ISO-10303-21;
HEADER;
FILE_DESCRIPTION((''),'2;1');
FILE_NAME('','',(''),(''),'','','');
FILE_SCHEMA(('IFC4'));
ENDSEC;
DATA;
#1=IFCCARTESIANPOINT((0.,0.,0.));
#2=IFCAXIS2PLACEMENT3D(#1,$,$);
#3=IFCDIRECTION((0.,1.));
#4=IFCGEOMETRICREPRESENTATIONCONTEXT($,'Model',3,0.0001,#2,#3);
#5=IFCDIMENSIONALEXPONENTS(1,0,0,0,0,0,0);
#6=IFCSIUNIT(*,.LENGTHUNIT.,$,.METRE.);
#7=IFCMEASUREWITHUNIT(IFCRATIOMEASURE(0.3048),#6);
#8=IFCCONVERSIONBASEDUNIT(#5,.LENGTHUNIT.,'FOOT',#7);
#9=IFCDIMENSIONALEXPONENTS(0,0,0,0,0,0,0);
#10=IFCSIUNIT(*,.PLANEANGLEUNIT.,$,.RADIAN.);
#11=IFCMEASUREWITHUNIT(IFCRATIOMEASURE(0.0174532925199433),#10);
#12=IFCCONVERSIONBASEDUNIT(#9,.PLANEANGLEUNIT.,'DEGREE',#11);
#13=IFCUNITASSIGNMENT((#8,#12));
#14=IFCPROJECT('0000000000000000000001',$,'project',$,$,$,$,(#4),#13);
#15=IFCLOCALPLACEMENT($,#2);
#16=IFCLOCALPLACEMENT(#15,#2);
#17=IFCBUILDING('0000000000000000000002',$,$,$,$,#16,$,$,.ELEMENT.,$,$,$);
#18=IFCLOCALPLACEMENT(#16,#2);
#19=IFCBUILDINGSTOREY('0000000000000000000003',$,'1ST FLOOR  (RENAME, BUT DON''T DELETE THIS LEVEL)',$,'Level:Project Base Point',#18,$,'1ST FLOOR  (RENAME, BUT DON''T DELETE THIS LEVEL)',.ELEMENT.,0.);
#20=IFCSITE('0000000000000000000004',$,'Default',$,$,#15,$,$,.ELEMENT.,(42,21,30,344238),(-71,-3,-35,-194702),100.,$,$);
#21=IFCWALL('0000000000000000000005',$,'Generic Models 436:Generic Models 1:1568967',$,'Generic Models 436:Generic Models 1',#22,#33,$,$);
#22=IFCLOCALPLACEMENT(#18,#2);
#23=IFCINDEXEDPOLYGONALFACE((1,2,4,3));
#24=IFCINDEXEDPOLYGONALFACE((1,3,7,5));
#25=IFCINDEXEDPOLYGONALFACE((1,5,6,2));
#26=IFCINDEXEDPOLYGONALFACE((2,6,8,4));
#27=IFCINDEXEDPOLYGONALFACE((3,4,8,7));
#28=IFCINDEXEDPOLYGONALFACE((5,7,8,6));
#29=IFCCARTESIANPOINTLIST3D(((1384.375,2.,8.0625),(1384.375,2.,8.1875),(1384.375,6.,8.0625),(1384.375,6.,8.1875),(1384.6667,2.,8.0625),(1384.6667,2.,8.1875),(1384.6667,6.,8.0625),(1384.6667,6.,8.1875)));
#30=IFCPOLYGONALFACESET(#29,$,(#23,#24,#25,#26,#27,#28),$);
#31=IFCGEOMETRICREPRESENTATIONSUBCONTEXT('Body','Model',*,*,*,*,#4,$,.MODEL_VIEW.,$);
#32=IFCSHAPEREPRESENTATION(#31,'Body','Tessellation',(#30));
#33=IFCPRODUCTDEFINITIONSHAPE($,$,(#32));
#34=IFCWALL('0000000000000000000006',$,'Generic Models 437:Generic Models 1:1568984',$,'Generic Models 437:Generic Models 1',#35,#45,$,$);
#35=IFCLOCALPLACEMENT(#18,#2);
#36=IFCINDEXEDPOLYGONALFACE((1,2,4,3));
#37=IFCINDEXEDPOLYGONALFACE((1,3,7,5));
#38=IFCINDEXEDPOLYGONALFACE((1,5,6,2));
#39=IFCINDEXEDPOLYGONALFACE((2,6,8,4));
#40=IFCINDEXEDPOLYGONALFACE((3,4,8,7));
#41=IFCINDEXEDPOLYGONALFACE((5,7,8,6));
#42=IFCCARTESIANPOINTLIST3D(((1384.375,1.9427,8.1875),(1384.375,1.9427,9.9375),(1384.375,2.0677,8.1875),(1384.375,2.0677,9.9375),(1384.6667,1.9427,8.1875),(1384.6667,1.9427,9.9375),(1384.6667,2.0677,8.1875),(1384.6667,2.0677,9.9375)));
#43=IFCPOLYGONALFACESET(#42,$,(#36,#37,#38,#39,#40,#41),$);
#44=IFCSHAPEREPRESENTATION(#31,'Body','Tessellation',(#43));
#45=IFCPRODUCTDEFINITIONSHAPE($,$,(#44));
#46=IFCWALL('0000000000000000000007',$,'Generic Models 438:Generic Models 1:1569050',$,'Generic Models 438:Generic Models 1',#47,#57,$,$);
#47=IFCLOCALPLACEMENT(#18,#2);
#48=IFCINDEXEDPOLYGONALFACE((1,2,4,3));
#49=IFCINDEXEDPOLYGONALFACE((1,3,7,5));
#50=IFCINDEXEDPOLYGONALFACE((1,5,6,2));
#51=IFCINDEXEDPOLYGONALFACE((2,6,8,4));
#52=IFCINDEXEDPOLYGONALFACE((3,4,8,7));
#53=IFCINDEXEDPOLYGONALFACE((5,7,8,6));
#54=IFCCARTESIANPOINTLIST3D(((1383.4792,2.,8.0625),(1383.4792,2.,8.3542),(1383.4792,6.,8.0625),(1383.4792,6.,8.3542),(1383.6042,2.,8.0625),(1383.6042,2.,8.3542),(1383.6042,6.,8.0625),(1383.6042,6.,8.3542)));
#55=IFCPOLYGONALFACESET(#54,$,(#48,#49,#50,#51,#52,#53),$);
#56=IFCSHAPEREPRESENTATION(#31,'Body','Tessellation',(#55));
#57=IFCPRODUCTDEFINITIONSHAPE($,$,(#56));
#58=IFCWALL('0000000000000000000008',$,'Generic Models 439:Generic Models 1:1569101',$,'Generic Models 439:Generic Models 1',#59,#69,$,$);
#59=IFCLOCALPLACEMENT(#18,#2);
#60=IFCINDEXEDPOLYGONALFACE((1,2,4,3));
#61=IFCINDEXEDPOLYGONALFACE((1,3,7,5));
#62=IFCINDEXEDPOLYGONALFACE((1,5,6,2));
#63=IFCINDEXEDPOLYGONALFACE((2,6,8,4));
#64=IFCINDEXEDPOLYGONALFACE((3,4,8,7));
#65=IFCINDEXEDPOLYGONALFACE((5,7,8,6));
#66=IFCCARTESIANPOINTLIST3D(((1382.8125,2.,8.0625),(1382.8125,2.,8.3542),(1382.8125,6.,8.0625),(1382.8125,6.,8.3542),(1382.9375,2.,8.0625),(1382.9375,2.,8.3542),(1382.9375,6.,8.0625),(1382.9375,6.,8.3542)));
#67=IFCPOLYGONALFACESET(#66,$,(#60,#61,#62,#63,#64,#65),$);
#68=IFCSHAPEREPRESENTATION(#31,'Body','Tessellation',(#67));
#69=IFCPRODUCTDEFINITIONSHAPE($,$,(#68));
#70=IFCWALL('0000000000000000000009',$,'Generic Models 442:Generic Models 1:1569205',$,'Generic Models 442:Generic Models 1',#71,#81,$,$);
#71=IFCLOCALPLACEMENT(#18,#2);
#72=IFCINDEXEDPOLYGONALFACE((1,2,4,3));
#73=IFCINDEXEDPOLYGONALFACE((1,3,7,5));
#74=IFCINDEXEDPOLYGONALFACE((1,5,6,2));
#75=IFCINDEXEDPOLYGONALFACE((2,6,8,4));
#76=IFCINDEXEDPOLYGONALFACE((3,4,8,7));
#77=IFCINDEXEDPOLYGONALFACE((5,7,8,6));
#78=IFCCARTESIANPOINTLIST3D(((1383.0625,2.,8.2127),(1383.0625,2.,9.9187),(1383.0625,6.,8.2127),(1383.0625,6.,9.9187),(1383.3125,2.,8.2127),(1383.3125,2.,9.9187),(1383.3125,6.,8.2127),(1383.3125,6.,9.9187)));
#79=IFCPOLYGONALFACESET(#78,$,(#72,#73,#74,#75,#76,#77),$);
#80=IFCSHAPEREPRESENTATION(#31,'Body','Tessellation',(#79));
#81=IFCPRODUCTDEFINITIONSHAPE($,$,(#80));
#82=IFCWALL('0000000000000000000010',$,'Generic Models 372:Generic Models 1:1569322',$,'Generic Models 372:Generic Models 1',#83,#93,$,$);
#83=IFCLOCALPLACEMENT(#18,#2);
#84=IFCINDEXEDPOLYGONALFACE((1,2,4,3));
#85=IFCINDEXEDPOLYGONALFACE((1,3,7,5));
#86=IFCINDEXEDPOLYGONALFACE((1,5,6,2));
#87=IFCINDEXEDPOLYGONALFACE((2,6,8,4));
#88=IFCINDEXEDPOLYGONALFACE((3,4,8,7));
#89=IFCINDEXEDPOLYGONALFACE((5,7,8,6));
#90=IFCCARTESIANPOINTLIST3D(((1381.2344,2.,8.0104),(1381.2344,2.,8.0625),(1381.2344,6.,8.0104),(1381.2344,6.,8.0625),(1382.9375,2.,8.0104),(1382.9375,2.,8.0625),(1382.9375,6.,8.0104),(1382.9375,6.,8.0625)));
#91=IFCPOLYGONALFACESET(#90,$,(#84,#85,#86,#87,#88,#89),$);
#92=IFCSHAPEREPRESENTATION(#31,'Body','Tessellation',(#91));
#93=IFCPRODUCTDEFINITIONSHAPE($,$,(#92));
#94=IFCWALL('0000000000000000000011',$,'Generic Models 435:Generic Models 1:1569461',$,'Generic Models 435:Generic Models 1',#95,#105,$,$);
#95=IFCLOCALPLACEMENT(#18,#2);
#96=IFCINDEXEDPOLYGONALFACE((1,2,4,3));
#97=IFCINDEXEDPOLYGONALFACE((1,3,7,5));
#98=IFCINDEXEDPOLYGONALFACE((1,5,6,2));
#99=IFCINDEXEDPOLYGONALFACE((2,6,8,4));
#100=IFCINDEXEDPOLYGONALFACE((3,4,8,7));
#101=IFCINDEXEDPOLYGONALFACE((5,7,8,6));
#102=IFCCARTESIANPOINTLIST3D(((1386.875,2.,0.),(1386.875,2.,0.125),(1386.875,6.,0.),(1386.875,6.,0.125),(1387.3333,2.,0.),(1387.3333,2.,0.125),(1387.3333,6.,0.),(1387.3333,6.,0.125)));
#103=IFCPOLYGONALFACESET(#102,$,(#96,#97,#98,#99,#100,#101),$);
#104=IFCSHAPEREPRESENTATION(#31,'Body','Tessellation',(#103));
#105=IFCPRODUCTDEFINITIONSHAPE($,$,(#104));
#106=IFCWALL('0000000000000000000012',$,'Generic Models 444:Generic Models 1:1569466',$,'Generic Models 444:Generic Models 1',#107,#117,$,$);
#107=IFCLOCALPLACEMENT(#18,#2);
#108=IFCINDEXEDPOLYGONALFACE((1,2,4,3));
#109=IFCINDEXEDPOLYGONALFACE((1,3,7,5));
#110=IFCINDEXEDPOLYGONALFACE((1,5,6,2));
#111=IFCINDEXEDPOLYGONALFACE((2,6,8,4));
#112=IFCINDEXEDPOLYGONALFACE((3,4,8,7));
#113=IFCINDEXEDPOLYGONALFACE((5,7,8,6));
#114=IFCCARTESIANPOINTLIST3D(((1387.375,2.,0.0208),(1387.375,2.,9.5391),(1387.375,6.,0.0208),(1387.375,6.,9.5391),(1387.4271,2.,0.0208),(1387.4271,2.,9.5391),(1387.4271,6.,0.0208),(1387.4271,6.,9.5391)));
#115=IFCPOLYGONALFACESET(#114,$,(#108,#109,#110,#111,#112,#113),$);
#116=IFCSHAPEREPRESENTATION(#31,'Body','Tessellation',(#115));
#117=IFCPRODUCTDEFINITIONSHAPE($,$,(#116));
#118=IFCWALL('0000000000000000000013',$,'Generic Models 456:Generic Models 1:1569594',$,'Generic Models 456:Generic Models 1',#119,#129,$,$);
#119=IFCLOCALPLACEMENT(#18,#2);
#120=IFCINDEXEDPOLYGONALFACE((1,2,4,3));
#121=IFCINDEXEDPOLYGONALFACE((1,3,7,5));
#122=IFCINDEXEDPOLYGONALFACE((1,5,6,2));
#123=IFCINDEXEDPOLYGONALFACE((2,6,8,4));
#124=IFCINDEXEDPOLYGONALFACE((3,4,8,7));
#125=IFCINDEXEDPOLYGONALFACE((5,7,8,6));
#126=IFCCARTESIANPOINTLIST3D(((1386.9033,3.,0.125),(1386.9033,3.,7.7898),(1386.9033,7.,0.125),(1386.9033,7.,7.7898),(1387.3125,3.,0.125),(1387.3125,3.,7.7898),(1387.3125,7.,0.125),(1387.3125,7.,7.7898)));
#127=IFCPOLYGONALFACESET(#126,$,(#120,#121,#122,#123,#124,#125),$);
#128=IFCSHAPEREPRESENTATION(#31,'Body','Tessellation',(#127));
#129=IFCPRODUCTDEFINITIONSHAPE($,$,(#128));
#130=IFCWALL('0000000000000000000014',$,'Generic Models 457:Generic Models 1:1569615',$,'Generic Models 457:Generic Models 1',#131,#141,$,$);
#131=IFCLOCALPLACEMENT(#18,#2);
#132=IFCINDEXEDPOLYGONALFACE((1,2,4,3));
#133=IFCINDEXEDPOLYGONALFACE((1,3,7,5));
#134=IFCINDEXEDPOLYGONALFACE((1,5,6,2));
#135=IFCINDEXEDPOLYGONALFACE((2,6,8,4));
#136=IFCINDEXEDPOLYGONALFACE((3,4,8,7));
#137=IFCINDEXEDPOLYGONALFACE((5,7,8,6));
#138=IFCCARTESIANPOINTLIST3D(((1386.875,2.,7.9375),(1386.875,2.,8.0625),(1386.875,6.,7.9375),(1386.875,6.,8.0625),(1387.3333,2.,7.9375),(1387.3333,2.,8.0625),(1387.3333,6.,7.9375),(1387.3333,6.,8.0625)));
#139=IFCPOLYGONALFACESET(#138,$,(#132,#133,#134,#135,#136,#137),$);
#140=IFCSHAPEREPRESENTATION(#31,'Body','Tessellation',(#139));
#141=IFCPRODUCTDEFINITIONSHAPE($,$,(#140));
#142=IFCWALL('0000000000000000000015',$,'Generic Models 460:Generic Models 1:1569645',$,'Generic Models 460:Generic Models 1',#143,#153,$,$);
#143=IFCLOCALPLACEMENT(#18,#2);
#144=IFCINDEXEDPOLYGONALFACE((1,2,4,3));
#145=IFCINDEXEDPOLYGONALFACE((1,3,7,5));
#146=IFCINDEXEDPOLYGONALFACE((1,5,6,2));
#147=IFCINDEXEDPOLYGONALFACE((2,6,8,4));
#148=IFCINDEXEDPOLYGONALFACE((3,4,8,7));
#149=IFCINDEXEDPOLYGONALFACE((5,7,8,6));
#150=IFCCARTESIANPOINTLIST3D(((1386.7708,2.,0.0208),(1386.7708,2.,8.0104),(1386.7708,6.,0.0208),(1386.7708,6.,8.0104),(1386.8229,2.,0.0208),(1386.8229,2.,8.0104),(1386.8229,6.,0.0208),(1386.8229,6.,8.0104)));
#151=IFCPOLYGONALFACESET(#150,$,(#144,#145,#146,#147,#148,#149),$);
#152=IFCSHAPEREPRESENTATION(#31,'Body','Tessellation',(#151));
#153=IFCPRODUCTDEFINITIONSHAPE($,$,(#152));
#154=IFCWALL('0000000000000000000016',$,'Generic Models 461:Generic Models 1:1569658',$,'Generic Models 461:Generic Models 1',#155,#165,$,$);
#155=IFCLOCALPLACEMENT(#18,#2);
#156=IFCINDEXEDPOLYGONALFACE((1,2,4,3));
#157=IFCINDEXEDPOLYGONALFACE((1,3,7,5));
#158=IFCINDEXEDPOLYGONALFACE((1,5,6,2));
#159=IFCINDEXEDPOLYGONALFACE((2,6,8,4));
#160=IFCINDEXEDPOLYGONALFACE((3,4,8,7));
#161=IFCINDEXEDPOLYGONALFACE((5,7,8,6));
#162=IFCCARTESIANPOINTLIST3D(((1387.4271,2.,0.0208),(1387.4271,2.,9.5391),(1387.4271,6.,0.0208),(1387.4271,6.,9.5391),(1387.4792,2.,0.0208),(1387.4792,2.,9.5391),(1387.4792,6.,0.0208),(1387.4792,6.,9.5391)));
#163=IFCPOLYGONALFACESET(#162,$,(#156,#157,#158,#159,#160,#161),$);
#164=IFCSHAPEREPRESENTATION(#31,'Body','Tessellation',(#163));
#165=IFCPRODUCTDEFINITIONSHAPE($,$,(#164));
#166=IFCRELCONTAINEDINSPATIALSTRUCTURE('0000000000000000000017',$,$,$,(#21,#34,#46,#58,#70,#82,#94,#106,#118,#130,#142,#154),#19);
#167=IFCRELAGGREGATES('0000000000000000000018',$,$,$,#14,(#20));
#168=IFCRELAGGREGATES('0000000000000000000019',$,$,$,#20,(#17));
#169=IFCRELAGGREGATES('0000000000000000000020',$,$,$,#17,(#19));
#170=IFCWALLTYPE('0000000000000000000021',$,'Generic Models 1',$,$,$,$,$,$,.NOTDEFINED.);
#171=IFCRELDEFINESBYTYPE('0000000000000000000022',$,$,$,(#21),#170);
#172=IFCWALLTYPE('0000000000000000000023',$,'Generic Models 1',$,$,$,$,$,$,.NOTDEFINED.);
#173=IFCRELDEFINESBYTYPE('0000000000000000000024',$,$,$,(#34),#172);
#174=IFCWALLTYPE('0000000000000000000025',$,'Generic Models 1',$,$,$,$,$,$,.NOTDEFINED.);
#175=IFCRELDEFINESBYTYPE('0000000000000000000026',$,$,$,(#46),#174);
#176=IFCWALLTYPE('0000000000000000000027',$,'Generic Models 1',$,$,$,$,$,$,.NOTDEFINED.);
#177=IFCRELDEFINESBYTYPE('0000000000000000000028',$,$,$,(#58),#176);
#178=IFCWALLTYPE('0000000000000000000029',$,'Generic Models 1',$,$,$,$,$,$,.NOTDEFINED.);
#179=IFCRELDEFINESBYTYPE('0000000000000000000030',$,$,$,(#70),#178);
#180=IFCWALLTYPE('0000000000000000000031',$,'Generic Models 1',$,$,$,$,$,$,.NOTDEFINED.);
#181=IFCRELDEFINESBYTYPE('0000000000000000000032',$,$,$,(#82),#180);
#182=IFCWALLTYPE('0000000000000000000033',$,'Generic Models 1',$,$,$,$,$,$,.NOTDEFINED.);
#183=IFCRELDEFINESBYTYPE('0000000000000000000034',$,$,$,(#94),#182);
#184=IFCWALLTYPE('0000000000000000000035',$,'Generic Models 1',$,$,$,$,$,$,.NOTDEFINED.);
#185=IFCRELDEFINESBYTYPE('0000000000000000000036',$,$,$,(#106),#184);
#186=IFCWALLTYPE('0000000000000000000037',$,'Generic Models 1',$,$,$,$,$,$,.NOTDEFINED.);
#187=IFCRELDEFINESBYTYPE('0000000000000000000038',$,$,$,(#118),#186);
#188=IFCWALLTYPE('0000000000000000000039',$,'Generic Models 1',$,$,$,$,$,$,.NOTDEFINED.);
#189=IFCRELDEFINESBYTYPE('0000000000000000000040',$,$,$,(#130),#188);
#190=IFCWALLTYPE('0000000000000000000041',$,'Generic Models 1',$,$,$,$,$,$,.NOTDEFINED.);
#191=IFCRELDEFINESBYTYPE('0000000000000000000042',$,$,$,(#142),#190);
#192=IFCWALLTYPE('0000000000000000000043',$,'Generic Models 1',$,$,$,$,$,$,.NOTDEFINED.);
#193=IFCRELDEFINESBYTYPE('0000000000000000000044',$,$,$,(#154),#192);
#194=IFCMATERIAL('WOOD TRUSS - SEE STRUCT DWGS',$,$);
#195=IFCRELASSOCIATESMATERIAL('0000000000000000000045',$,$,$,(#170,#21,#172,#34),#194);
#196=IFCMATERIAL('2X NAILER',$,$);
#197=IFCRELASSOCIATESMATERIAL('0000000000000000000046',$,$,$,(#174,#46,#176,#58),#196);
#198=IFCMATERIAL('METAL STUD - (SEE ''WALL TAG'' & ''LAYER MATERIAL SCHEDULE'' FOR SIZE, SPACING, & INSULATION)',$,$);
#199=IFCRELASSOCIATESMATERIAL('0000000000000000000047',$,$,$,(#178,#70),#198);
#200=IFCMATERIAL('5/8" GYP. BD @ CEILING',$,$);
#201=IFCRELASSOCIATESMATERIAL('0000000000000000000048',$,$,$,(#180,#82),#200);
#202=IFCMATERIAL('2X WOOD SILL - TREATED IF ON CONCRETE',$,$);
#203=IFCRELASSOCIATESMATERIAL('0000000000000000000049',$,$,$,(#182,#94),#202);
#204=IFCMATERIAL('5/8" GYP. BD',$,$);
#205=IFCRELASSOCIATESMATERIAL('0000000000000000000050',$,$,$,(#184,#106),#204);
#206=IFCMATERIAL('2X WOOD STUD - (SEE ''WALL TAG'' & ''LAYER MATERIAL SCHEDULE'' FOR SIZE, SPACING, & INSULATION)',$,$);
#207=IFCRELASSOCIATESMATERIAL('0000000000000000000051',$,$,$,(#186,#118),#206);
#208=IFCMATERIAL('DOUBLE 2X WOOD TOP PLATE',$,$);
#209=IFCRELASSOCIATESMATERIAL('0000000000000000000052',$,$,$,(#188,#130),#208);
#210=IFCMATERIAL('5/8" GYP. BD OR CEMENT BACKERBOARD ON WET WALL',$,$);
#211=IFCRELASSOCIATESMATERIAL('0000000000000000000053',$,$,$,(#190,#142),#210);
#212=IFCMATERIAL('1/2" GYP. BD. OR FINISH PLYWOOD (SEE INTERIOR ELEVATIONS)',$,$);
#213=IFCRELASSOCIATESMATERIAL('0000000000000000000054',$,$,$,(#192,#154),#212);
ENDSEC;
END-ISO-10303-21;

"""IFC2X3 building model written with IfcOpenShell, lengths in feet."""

from ifc_helpers import new_model, entity, si_unit, converted_unit, direction, frame, frame_2d, origin, origin_2d_with_axis, place, context, subcontext, project, spatial, rectangle, extrude, material, type_object, element, save


model = new_model("IFC2X3")

# Units and contexts
model_context = context("Model", 3, precision=0.0001, world=origin(), true_north=direction((0.0, 1.0)))
body_context = subcontext(model_context, "Body", "Model", "MODEL_VIEW")
ifc_project = project(units=[converted_unit("LENGTHUNIT", "FOOT", entity("IfcRatioMeasure", 0.3048), si_unit("LENGTHUNIT", "METRE"), dimensions=[1, 0, 0, 0, 0, 0, 0]), converted_unit("PLANEANGLEUNIT", "DEGREE", entity("IfcRatioMeasure", 0.0174532925199433), si_unit("PLANEANGLEUNIT", "RADIAN"), dimensions=[0, 0, 0, 0, 0, 0, 0])], contexts=[model_context])

# Site, building, storey
site_placement = place(None, origin())
site = spatial("IfcSite", under=ifc_project, at=site_placement, Name="Default", CompositionType="ELEMENT", RefLatitude=(42, 21, 30, 344238), RefLongitude=(-71, -3, -35, -194702), RefElevation=100.0)
building_placement = place(site_placement, origin())
building = spatial("IfcBuilding", under=site, at=building_placement, CompositionType="ELEMENT")
storey_placement = place(building_placement, origin())
storey = spatial("IfcBuildingStorey", under=building, at=storey_placement, Name="1ST FLOOR  (RENAME, BUT DON'T DELETE THIS LEVEL)", ObjectType="Level:Project Base Point", LongName="1ST FLOOR  (RENAME, BUT DON'T DELETE THIS LEVEL)", CompositionType="ELEMENT", Elevation=0.0)

# Walls
ifc_material_1 = material(Name="2X WOOD SILL - TREATED IF ON CONCRETE")
ifc_material_2 = material(Name="5/8\" GYP. BD")
ifc_material_3 = material(Name="DOUBLE 2X WOOD TOP PLATE")
ifc_material_4 = material(Name="2X WOOD STUD - (SEE 'WALL TAG' & 'LAYER MATERIAL SCHEDULE' FOR SIZE, SPACING, & INSULATION)")
ifc_material_5 = material(Name="5/8\" GYP. BD OR CEMENT BACKERBOARD ON WET WALL")
ifc_material_6 = material(Name="5/8\" GYP. BD @ CEILING")
ifc_material_7 = material(Name="WOOD TRUSS - SEE STRUCT DWGS")
wall_type_1 = type_object("IfcWallType", Name="Generic Models 1", PredefinedType="NOTDEFINED", material=ifc_material_7)
wall_1_placement = place(storey_placement, frame((1384.375, 2.0, 8.0625), z_axis=(0.0, 0.0, 1.0), x_axis=(0.0, 1.0, 0.0)))
element("IfcWall", 1, at=wall_1_placement, inside=storey, type_object=wall_type_1, material=ifc_material_7, Name="Generic Models 436:Generic Models 1:1568967", ObjectType="Generic Models 436:Generic Models 1", context=body_context, shape_type="SweptSolid", body=[
    extrude(rectangle(XDim=4.0, YDim=0.2917, at=frame_2d((0.0, 0.0), x_axis=(1.0, 0.0))), frame((2.0, -0.1458, 0.0)), (0.0, 0.0, 1.0), 0.125),
])
wall_type_2 = type_object("IfcWallType", Name="Generic Models 1", PredefinedType="NOTDEFINED", material=ifc_material_7)
wall_2_placement = place(storey_placement, frame((1384.375, 1.9427, 8.1875)))
element("IfcWall", 2, at=wall_2_placement, inside=storey, type_object=wall_type_2, material=ifc_material_7, Name="Generic Models 437:Generic Models 1:1568984", ObjectType="Generic Models 437:Generic Models 1", context=body_context, shape_type="SweptSolid", body=[
    extrude(rectangle(XDim=0.125, YDim=0.2917, at=frame_2d((0.0, 0.0), x_axis=(1.0, 0.0))), frame((0.1458, 0.0625, 0.0), z_axis=(0.0, 0.0, 1.0), x_axis=(0.0, 1.0, 0.0)), (0.0, 0.0, 1.0), 1.75),
])
ifc_material_8 = material(Name="2X NAILER")
wall_type_3 = type_object("IfcWallType", Name="Generic Models 1", PredefinedType="NOTDEFINED", material=ifc_material_8)
wall_3_placement = place(storey_placement, frame((1383.4792, 2.0, 8.0625), z_axis=(0.0, 0.0, 1.0), x_axis=(0.0, 1.0, 0.0)))
element("IfcWall", 3, at=wall_3_placement, inside=storey, type_object=wall_type_3, material=ifc_material_8, Name="Generic Models 438:Generic Models 1:1569050", ObjectType="Generic Models 438:Generic Models 1", context=body_context, shape_type="SweptSolid", body=[
    extrude(rectangle(XDim=4.0, YDim=0.125, at=frame_2d((0.0, 0.0), x_axis=(1.0, 0.0))), frame((2.0, -0.0625, 0.0)), (0.0, 0.0, 1.0), 0.2917),
])
wall_type_4 = type_object("IfcWallType", Name="Generic Models 1", PredefinedType="NOTDEFINED", material=ifc_material_8)
wall_4_placement = place(storey_placement, frame((1382.8125, 2.0, 8.0625), z_axis=(0.0, 0.0, 1.0), x_axis=(0.0, 1.0, 0.0)))
element("IfcWall", 4, at=wall_4_placement, inside=storey, type_object=wall_type_4, material=ifc_material_8, Name="Generic Models 439:Generic Models 1:1569101", ObjectType="Generic Models 439:Generic Models 1", context=body_context, shape_type="SweptSolid", body=[
    extrude(rectangle(XDim=4.0, YDim=0.125, at=frame_2d((0.0, 0.0), x_axis=(1.0, 0.0))), frame((2.0, -0.0625, 0.0)), (0.0, 0.0, 1.0), 0.2917),
])
ifc_material_9 = material(Name="METAL STUD - (SEE 'WALL TAG' & 'LAYER MATERIAL SCHEDULE' FOR SIZE, SPACING, & INSULATION)")
wall_type_5 = type_object("IfcWallType", Name="Generic Models 1", PredefinedType="NOTDEFINED", material=ifc_material_9)
wall_5_placement = place(storey_placement, frame((1383.0625, 2.0, 8.2127), z_axis=(0.0, 0.0, 1.0), x_axis=(0.0, 1.0, 0.0)))
element("IfcWall", 5, at=wall_5_placement, inside=storey, type_object=wall_type_5, material=ifc_material_9, Name="Generic Models 442:Generic Models 1:1569205", ObjectType="Generic Models 442:Generic Models 1", context=body_context, shape_type="SweptSolid", body=[
    extrude(rectangle(XDim=4.0, YDim=0.25, at=origin_2d_with_axis()), frame((2.0, -0.125, 0.0)), (0.0, 0.0, 1.0), 1.706),
])
wall_type_6 = type_object("IfcWallType", Name="Generic Models 1", PredefinedType="NOTDEFINED", material=ifc_material_6)
wall_6_placement = place(storey_placement, frame((1381.2344, 2.0, 8.0104), z_axis=(0.0, 0.0, 1.0), x_axis=(0.0, 1.0, 0.0)))
element("IfcWall", 6, at=wall_6_placement, inside=storey, type_object=wall_type_6, material=ifc_material_6, Name="Generic Models 372:Generic Models 1:1569322", ObjectType="Generic Models 372:Generic Models 1", context=body_context, shape_type="SweptSolid", body=[
    extrude(rectangle(XDim=4.0, YDim=1.7031, at=origin_2d_with_axis()), frame((2.0, -0.8516, 0.0)), (0.0, 0.0, 1.0), 0.0521),
])
wall_type_7 = type_object("IfcWallType", Name="Generic Models 1", PredefinedType="NOTDEFINED", material=ifc_material_1)
wall_7_placement = place(storey_placement, frame((1386.875, 2.0, 0.0), z_axis=(0.0, 0.0, 1.0), x_axis=(0.0, 1.0, 0.0)))
element("IfcWall", 7, at=wall_7_placement, inside=storey, type_object=wall_type_7, material=ifc_material_1, Name="Generic Models 435:Generic Models 1:1569461", ObjectType="Generic Models 435:Generic Models 1", context=body_context, shape_type="SweptSolid", body=[
    extrude(rectangle(XDim=4.0, YDim=0.4583, at=frame_2d((0.0, 0.0), x_axis=(1.0, 0.0))), frame((2.0, -0.2292, 0.0)), (0.0, 0.0, 1.0), 0.125),
])
wall_type_8 = type_object("IfcWallType", Name="Generic Models 1", PredefinedType="NOTDEFINED", material=ifc_material_2)
wall_8_placement = place(storey_placement, frame((1387.375, 2.0, 0.0208), z_axis=(0.0, 0.0, 1.0), x_axis=(0.0, 1.0, 0.0)))
element("IfcWall", 8, at=wall_8_placement, inside=storey, type_object=wall_type_8, material=ifc_material_2, Name="Generic Models 444:Generic Models 1:1569466", ObjectType="Generic Models 444:Generic Models 1", context=body_context, shape_type="SweptSolid", body=[
    extrude(rectangle(XDim=4.0, YDim=0.0521, at=frame_2d((0.0, 0.0), x_axis=(1.0, 0.0))), frame((2.0, -0.026, 0.0)), (0.0, 0.0, 1.0), 9.5182),
])
wall_type_9 = type_object("IfcWallType", Name="Generic Models 1", PredefinedType="NOTDEFINED", material=ifc_material_4)
wall_9_placement = place(storey_placement, frame((1386.9033, 3.0, 0.125), z_axis=(0.0, 0.0, 1.0), x_axis=(0.0, 1.0, 0.0)))
element("IfcWall", 9, at=wall_9_placement, inside=storey, type_object=wall_type_9, material=ifc_material_4, Name="Generic Models 456:Generic Models 1:1569594", ObjectType="Generic Models 456:Generic Models 1", context=body_context, shape_type="SweptSolid", body=[
    extrude(rectangle(XDim=4.0, YDim=0.4092, at=frame_2d((0.0, 0.0), x_axis=(1.0, 0.0))), frame((2.0, -0.2046, 0.0)), (0.0, 0.0, 1.0), 7.6648),
])
wall_type_10 = type_object("IfcWallType", Name="Generic Models 1", PredefinedType="NOTDEFINED", material=ifc_material_3)
wall_10_placement = place(storey_placement, frame((1386.875, 2.0, 7.9375), z_axis=(0.0, 0.0, 1.0), x_axis=(0.0, 1.0, 0.0)))
element("IfcWall", 10, at=wall_10_placement, inside=storey, type_object=wall_type_10, material=ifc_material_3, Name="Generic Models 457:Generic Models 1:1569615", ObjectType="Generic Models 457:Generic Models 1", context=body_context, shape_type="SweptSolid", body=[
    extrude(rectangle(XDim=4.0, YDim=0.4583, at=frame_2d((0.0, 0.0), x_axis=(1.0, 0.0))), frame((2.0, -0.2292, 0.0)), (0.0, 0.0, 1.0), 0.125),
])
wall_type_11 = type_object("IfcWallType", Name="Generic Models 1", PredefinedType="NOTDEFINED", material=ifc_material_5)
wall_11_placement = place(storey_placement, frame((1386.7708, 2.0, 0.0208), z_axis=(0.0, 0.0, 1.0), x_axis=(0.0, 1.0, 0.0)))
element("IfcWall", 11, at=wall_11_placement, inside=storey, type_object=wall_type_11, material=ifc_material_5, Name="Generic Models 460:Generic Models 1:1569645", ObjectType="Generic Models 460:Generic Models 1", context=body_context, shape_type="SweptSolid", body=[
    extrude(rectangle(XDim=4.0, YDim=0.0521, at=frame_2d((0.0, 0.0), x_axis=(1.0, 0.0))), frame((2.0, -0.026, 0.0)), (0.0, 0.0, 1.0), 7.9896),
])
ifc_material_10 = material(Name="1/2\" GYP. BD. OR FINISH PLYWOOD (SEE INTERIOR ELEVATIONS)")
wall_type_12 = type_object("IfcWallType", Name="Generic Models 1", PredefinedType="NOTDEFINED", material=ifc_material_10)
wall_12_placement = place(storey_placement, frame((1387.4271, 2.0, 0.0208), z_axis=(0.0, 0.0, 1.0), x_axis=(0.0, 1.0, 0.0)))
element("IfcWall", 12, at=wall_12_placement, inside=storey, type_object=wall_type_12, material=ifc_material_10, Name="Generic Models 461:Generic Models 1:1569658", ObjectType="Generic Models 461:Generic Models 1", context=body_context, shape_type="SweptSolid", body=[
    extrude(rectangle(XDim=4.0, YDim=0.0521, at=frame_2d((0.0, 0.0), x_axis=(1.0, 0.0))), frame((2.0, -0.026, 0.0)), (0.0, 0.0, 1.0), 9.5182),
])

save(model, "model.ifc")
